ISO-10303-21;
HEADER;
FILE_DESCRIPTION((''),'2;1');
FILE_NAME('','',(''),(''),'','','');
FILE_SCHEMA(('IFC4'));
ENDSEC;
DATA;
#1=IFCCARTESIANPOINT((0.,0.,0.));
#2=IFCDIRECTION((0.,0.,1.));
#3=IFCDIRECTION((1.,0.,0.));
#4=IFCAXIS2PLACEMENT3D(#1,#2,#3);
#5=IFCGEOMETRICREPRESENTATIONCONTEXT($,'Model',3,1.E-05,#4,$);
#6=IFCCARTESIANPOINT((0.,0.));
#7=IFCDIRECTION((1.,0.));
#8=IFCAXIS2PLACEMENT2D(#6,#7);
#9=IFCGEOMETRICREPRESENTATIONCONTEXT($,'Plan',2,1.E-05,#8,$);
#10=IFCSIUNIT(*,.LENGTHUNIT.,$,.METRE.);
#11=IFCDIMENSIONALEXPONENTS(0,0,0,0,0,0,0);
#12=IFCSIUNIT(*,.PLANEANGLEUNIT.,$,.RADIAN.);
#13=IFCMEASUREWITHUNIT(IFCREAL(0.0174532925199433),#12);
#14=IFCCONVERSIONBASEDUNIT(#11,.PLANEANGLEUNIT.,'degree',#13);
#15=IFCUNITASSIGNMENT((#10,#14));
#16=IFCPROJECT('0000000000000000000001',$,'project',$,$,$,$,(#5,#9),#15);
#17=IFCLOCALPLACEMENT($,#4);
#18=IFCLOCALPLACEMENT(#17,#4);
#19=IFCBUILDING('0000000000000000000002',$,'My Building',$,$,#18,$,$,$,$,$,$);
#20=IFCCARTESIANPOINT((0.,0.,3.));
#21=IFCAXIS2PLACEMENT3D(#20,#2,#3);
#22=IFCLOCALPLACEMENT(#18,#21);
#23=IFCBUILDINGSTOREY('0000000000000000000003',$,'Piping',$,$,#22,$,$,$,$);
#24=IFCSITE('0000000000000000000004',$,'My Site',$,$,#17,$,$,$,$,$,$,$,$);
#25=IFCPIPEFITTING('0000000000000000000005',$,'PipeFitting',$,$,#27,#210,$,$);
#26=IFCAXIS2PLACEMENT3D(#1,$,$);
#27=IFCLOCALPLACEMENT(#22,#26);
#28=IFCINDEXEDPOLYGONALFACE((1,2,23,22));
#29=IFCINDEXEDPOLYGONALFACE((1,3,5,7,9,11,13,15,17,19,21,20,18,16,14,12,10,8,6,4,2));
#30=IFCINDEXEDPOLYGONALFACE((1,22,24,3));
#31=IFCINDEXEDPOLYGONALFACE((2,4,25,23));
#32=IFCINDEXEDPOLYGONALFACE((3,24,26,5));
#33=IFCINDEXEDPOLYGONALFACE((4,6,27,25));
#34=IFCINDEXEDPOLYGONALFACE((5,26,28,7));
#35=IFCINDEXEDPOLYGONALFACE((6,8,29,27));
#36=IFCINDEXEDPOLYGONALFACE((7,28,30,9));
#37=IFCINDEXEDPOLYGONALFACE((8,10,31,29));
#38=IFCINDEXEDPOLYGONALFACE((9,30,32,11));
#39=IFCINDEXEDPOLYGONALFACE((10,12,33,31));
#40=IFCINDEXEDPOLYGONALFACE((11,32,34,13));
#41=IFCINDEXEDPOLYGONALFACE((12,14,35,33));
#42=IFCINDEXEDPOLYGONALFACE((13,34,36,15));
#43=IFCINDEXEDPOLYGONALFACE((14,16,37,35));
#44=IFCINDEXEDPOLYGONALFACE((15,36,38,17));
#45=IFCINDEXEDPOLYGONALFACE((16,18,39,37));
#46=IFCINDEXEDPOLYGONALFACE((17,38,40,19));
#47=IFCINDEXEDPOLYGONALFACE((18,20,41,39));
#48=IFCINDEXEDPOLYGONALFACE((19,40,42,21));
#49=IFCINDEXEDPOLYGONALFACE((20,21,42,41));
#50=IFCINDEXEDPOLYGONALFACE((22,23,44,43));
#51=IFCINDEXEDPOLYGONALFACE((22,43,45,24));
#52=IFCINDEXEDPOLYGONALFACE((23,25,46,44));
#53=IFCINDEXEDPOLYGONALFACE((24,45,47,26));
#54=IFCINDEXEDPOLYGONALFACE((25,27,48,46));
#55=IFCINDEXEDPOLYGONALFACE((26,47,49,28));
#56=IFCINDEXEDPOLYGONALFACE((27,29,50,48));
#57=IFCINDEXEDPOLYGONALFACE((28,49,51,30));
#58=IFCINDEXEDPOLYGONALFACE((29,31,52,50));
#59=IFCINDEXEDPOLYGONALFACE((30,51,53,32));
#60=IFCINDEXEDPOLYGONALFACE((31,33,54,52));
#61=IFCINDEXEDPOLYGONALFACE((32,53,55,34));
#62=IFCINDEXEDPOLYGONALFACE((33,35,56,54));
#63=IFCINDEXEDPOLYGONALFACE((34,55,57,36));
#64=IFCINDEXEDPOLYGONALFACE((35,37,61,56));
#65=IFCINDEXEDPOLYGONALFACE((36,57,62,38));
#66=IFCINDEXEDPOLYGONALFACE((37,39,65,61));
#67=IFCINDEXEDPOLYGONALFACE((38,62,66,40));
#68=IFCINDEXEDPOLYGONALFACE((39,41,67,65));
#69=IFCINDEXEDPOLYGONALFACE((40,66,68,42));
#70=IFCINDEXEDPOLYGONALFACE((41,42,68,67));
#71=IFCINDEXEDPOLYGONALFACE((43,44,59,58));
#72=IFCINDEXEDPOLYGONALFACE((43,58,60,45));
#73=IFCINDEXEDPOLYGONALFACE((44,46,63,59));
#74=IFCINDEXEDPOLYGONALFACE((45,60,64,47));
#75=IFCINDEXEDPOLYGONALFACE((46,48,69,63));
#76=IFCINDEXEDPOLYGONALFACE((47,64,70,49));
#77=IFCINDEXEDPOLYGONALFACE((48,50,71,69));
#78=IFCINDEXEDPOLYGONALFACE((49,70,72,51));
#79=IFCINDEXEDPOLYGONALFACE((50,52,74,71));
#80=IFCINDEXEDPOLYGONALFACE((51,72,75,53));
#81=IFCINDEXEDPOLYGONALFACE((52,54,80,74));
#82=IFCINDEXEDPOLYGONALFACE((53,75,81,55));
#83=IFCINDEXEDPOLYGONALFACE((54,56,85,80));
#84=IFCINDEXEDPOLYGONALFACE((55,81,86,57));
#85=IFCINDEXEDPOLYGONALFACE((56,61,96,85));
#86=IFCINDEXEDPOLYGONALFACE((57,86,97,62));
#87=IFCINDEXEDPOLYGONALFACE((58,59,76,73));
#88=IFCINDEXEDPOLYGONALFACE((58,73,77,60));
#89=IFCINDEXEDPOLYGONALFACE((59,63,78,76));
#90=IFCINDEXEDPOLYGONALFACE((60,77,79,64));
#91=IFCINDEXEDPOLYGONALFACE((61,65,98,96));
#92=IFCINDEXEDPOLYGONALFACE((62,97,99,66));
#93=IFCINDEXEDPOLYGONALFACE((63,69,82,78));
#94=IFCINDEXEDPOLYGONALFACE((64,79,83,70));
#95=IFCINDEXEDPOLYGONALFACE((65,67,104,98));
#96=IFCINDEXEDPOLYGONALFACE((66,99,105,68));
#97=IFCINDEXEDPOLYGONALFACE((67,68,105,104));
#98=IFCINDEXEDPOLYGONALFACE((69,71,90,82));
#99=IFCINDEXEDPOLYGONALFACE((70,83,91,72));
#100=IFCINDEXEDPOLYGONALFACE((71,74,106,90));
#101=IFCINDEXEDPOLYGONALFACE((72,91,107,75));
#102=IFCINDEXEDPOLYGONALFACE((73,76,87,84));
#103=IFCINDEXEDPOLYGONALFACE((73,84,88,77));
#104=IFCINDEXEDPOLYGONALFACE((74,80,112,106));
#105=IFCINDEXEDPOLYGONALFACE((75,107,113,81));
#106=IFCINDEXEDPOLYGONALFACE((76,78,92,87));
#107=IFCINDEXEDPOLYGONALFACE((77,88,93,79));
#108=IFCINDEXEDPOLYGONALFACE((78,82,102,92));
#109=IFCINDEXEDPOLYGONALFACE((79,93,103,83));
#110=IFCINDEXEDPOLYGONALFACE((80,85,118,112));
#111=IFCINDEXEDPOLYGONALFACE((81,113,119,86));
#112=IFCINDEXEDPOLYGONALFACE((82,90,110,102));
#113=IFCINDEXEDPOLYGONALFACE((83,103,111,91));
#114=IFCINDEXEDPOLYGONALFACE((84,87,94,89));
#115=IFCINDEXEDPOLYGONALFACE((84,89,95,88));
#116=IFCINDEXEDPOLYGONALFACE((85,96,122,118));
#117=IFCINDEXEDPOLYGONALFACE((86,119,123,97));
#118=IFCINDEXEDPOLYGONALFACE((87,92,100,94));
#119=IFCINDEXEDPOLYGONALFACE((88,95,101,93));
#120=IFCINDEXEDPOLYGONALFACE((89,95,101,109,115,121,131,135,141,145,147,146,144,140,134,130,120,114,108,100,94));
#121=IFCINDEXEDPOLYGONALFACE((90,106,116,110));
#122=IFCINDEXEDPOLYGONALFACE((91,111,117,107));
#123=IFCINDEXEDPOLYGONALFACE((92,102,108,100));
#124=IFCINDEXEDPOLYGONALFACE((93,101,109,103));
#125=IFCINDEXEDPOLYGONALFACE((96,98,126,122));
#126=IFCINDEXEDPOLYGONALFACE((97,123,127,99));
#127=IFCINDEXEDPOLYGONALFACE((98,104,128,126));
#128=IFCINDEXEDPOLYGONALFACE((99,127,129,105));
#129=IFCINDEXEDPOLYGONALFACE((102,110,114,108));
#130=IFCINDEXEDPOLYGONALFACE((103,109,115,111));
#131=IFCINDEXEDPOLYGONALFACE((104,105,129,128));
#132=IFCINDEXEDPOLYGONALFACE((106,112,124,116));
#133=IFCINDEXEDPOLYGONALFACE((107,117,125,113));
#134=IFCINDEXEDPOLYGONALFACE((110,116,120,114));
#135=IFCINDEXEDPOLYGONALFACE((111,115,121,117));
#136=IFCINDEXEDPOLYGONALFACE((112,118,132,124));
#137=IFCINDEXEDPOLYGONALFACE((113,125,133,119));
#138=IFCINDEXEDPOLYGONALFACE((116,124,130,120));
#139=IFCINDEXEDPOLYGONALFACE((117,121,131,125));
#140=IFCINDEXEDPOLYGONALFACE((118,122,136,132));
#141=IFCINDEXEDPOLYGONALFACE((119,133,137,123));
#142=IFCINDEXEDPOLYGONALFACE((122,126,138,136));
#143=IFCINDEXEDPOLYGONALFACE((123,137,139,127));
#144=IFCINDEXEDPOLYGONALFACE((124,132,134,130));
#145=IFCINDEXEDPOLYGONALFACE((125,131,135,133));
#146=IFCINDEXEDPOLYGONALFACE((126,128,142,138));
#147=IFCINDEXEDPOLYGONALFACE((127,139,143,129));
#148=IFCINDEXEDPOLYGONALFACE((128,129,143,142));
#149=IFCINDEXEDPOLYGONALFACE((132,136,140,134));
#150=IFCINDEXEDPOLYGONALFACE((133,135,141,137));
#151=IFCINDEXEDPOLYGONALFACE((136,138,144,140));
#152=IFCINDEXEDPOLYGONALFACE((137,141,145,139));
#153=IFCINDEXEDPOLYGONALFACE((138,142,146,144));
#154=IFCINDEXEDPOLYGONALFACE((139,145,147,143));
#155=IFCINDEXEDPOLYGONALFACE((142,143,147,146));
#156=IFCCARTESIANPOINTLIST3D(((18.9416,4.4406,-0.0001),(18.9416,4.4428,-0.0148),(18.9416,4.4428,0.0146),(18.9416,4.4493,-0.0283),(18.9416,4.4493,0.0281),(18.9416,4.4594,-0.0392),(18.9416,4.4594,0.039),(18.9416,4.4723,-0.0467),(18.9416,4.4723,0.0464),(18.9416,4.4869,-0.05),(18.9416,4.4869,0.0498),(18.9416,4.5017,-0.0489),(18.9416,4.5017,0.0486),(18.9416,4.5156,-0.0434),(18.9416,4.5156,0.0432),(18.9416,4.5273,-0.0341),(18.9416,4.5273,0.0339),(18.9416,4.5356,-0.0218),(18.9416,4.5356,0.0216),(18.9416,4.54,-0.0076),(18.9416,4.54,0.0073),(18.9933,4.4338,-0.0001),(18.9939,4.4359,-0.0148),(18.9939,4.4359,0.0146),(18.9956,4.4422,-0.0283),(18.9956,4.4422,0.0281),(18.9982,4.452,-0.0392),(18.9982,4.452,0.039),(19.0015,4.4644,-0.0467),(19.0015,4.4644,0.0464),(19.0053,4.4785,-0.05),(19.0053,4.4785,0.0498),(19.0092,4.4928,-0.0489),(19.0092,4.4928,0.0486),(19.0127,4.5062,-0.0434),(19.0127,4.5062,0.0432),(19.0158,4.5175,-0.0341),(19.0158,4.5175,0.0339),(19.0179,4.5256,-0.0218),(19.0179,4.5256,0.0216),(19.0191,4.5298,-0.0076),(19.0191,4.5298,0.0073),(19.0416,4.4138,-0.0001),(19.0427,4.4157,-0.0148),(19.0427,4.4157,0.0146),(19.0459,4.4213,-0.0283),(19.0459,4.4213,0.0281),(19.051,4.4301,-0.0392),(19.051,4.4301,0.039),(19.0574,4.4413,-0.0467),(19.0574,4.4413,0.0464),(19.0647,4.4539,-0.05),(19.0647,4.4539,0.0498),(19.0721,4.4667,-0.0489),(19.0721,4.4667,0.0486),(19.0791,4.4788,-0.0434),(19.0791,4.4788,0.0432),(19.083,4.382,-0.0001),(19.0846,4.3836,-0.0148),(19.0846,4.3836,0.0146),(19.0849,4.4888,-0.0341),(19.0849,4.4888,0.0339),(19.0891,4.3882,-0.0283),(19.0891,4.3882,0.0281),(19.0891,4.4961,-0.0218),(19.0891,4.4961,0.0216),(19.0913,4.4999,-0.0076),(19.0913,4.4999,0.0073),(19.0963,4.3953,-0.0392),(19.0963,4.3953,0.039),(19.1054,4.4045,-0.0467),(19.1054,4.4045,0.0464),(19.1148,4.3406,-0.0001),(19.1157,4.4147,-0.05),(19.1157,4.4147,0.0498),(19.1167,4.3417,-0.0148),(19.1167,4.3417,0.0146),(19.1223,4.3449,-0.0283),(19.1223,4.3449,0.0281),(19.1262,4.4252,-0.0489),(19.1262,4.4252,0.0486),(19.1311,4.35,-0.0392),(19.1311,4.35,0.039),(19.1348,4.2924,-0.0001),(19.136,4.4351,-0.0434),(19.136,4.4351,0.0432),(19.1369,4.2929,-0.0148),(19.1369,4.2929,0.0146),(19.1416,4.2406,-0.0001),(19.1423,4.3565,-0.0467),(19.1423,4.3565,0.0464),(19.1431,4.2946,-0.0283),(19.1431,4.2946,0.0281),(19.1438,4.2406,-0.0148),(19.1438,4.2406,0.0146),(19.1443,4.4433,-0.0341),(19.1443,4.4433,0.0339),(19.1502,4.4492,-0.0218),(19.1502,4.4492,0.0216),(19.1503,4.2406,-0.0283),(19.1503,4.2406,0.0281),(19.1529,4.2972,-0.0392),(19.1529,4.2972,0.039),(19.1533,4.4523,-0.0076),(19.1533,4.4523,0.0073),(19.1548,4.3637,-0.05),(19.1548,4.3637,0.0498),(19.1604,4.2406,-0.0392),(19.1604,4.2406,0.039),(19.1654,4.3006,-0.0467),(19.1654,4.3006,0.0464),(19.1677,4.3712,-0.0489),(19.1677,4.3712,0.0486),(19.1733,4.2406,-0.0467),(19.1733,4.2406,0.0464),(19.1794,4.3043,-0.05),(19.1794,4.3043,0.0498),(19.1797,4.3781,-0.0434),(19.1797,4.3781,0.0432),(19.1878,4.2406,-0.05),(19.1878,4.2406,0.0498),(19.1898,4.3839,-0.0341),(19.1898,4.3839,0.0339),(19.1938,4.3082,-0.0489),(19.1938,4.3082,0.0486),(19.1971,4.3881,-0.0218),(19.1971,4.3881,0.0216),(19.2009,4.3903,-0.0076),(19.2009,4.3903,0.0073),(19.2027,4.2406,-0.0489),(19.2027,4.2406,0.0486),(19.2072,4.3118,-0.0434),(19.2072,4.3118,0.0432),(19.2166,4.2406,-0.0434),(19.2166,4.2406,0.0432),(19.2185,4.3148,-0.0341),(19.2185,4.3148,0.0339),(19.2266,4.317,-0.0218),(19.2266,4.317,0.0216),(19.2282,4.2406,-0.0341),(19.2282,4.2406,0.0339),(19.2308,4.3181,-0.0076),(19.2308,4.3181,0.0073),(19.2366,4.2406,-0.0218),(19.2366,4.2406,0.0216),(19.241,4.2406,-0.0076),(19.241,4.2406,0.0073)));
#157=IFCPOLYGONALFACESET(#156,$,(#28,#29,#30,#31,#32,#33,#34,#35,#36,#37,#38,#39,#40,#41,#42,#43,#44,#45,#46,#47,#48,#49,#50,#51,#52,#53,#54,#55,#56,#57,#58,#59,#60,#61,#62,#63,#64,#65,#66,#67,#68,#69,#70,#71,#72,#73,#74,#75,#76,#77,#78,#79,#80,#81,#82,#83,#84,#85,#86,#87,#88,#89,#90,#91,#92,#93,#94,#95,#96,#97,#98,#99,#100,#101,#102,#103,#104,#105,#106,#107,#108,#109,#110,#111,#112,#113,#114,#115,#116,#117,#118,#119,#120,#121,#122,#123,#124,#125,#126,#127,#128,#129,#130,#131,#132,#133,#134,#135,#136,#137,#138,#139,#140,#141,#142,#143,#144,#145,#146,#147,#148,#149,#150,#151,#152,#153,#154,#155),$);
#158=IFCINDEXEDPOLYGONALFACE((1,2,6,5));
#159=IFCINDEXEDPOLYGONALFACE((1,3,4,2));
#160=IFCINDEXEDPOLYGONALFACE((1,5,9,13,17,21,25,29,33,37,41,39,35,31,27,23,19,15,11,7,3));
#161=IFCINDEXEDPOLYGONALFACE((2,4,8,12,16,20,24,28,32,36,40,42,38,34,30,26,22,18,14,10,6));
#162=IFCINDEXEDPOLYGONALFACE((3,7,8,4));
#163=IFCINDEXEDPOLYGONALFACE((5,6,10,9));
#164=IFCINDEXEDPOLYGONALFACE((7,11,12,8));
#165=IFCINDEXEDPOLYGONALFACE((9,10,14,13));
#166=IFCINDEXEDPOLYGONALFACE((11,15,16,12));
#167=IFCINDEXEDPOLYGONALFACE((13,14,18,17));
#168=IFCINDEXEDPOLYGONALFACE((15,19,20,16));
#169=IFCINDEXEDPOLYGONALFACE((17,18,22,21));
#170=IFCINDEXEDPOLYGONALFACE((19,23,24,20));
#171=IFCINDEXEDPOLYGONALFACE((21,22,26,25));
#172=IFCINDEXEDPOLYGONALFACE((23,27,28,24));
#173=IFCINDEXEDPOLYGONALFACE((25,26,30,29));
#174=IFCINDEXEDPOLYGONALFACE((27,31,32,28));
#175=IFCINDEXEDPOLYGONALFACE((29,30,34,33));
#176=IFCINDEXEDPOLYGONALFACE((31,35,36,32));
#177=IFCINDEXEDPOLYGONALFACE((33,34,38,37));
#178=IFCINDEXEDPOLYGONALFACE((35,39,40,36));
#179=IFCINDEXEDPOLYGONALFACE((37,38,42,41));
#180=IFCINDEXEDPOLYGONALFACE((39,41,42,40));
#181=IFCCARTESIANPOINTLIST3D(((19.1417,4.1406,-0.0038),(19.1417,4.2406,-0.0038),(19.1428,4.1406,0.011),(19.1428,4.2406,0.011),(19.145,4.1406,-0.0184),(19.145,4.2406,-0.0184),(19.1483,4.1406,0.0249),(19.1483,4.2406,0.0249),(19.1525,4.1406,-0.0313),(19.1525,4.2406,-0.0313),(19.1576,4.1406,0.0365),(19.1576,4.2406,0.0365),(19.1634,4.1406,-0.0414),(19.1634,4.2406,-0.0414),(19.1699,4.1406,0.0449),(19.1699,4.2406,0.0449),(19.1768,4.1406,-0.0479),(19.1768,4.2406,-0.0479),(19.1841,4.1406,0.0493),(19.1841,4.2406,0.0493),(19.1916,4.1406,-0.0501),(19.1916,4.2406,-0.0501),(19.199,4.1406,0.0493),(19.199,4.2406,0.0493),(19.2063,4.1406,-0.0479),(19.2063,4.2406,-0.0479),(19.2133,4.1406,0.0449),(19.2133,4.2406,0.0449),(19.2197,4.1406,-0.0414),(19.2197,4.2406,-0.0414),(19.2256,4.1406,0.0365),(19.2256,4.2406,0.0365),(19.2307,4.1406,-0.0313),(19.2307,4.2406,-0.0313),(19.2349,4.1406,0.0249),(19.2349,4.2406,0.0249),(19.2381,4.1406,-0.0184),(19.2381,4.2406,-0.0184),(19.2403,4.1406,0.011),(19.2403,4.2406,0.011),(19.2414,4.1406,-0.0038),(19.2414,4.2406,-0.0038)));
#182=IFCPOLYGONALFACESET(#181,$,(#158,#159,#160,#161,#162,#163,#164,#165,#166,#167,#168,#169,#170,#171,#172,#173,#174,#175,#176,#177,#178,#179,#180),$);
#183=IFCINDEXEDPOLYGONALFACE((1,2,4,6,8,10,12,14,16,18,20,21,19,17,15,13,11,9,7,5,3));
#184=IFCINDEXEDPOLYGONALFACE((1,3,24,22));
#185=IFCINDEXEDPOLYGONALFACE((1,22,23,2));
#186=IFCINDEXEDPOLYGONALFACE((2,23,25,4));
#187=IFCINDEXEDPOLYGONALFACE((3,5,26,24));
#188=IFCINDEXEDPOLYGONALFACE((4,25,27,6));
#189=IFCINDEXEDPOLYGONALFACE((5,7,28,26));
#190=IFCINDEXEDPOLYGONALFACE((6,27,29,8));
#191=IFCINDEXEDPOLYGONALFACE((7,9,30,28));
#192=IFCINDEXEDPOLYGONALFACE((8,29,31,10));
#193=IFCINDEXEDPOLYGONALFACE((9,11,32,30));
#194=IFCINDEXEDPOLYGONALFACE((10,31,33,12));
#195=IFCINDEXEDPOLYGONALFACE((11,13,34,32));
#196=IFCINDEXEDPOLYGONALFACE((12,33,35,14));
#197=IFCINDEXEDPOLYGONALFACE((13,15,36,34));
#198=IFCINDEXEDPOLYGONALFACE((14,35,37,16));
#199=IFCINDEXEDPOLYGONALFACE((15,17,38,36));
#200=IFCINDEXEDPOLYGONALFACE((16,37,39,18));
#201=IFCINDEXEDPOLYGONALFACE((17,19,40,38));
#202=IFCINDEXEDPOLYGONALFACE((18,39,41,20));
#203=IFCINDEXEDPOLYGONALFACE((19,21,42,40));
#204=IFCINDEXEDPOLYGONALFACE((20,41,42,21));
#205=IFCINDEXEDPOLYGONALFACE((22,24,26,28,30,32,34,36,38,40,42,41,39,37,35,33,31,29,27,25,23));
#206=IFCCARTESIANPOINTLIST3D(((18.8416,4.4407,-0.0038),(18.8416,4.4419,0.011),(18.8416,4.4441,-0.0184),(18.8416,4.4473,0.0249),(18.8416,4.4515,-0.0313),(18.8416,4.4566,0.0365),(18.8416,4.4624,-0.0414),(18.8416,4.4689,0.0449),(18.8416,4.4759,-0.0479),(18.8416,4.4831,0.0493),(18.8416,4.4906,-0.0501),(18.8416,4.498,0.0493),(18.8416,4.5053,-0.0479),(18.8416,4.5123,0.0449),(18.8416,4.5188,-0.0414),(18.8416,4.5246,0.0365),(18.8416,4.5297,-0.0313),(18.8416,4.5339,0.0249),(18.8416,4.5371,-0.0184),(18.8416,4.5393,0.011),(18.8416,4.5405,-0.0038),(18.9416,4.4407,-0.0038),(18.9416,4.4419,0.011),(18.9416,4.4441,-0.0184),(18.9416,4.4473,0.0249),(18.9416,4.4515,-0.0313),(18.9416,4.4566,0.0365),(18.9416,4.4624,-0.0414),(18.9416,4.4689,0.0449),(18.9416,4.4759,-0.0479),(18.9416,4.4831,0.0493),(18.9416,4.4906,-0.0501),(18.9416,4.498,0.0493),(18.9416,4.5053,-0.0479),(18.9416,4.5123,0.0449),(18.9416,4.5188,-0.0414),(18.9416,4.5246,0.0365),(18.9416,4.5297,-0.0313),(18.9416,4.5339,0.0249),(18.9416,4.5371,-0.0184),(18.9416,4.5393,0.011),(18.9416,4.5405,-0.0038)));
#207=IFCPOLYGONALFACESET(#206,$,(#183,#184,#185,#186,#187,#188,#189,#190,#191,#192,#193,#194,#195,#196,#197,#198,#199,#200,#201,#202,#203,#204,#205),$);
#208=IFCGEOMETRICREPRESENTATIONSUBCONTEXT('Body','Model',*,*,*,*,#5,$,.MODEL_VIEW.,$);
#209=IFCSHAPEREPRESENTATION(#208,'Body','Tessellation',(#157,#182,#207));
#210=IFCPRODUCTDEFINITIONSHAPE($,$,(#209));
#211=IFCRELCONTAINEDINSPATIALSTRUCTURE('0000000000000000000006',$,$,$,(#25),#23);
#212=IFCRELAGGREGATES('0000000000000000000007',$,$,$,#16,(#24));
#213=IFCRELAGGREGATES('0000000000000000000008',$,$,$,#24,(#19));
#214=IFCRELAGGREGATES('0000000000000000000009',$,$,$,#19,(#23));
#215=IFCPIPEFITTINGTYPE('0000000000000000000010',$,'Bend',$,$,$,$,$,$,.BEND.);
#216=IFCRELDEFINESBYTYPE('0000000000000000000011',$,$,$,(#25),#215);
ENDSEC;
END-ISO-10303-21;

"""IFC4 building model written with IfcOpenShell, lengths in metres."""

from ifc_helpers import new_model, entity, si_unit, converted_unit, frame, origin_with_axes, origin_2d_with_axis, place, context, subcontext, project, spatial, circle, extrude, source, transform, mapped, type_object, type_shapes, element, save


model = new_model("IFC4")

# Units and contexts
model_context = context("Model", 3, precision=1e-05, world=origin_with_axes())
plan_context = context("Plan", 2, precision=1e-05, world=origin_2d_with_axis())
body_context = subcontext(model_context, "Body", "Model", "MODEL_VIEW")
ifc_project = project(units=[si_unit("LENGTHUNIT", "METRE"), converted_unit("PLANEANGLEUNIT", "degree", entity("IfcReal", 0.0174532925199433), si_unit("PLANEANGLEUNIT", "RADIAN"), dimensions=[0, 0, 0, 0, 0, 0, 0])], contexts=[model_context, plan_context])

# Site, building, storey
site_placement = place(None, origin_with_axes())
site = spatial("IfcSite", under=ifc_project, at=site_placement, Name="My Site")
building_placement = place(site_placement, origin_with_axes())
building = spatial("IfcBuilding", under=site, at=building_placement, Name="My Building")
storey_placement = place(building_placement, frame((0.0, 0.0, 3.0), z_axis=(0.0, 0.0, 1.0), x_axis=(1.0, 0.0, 0.0)))
storey = spatial("IfcBuildingStorey", under=building, at=storey_placement, Name="Piping")

# Pipe fitting
pipe_fitting_type = type_object("IfcPipeFittingType", Name="Bend", PredefinedType="BEND")
shared_shape = source(origin_with_axes(), body_context, "Body", "SolidModel", [
    entity("IfcSweptDiskSolid", entity("IfcIndexedPolyCurve", entity("IfcCartesianPointList3D", [[0.0, 0.0, -0.1], [0.0, -0.0732, -0.2768], [0.0, -0.25, -0.35]]), [entity("IfcArcIndex", [1, 2, 3])]), 0.05),
    extrude(circle(Radius=0.05), origin_with_axes(), (0.0, 0.0, -1.0), 0.1),
    extrude(circle(Radius=0.05), frame((0.0, -0.25, -0.35), z_axis=(0.0, -1.0, 0.0), x_axis=(1.0, 0.0, 0.0)), (0.0, 0.0, 1.0), 0.1),
])
type_shapes(pipe_fitting_type, [shared_shape])
for number, where, z_axis, x_axis, name in (
    (1, (19.1916, 4.1406, -0.0001), (0.0, -1.0, 0.0), (0.0, 0.0, -1.0), "PipeFitting"),
):
    element("IfcPipeFitting", number, at=place(storey_placement, frame(where, z_axis=z_axis, x_axis=x_axis)), inside=storey, type_object=pipe_fitting_type, Name=name, context=body_context, shape_type="MappedRepresentation", body=[
        mapped(shared_shape, transform((0.0, 0.0, 0.0), x_axis=(1.0, 0.0, 0.0), y_axis=(0.0, 1.0, 0.0), z_axis=(0.0, 0.0, 1.0), scale=1.0)),
    ])

save(model, "model.ifc")
